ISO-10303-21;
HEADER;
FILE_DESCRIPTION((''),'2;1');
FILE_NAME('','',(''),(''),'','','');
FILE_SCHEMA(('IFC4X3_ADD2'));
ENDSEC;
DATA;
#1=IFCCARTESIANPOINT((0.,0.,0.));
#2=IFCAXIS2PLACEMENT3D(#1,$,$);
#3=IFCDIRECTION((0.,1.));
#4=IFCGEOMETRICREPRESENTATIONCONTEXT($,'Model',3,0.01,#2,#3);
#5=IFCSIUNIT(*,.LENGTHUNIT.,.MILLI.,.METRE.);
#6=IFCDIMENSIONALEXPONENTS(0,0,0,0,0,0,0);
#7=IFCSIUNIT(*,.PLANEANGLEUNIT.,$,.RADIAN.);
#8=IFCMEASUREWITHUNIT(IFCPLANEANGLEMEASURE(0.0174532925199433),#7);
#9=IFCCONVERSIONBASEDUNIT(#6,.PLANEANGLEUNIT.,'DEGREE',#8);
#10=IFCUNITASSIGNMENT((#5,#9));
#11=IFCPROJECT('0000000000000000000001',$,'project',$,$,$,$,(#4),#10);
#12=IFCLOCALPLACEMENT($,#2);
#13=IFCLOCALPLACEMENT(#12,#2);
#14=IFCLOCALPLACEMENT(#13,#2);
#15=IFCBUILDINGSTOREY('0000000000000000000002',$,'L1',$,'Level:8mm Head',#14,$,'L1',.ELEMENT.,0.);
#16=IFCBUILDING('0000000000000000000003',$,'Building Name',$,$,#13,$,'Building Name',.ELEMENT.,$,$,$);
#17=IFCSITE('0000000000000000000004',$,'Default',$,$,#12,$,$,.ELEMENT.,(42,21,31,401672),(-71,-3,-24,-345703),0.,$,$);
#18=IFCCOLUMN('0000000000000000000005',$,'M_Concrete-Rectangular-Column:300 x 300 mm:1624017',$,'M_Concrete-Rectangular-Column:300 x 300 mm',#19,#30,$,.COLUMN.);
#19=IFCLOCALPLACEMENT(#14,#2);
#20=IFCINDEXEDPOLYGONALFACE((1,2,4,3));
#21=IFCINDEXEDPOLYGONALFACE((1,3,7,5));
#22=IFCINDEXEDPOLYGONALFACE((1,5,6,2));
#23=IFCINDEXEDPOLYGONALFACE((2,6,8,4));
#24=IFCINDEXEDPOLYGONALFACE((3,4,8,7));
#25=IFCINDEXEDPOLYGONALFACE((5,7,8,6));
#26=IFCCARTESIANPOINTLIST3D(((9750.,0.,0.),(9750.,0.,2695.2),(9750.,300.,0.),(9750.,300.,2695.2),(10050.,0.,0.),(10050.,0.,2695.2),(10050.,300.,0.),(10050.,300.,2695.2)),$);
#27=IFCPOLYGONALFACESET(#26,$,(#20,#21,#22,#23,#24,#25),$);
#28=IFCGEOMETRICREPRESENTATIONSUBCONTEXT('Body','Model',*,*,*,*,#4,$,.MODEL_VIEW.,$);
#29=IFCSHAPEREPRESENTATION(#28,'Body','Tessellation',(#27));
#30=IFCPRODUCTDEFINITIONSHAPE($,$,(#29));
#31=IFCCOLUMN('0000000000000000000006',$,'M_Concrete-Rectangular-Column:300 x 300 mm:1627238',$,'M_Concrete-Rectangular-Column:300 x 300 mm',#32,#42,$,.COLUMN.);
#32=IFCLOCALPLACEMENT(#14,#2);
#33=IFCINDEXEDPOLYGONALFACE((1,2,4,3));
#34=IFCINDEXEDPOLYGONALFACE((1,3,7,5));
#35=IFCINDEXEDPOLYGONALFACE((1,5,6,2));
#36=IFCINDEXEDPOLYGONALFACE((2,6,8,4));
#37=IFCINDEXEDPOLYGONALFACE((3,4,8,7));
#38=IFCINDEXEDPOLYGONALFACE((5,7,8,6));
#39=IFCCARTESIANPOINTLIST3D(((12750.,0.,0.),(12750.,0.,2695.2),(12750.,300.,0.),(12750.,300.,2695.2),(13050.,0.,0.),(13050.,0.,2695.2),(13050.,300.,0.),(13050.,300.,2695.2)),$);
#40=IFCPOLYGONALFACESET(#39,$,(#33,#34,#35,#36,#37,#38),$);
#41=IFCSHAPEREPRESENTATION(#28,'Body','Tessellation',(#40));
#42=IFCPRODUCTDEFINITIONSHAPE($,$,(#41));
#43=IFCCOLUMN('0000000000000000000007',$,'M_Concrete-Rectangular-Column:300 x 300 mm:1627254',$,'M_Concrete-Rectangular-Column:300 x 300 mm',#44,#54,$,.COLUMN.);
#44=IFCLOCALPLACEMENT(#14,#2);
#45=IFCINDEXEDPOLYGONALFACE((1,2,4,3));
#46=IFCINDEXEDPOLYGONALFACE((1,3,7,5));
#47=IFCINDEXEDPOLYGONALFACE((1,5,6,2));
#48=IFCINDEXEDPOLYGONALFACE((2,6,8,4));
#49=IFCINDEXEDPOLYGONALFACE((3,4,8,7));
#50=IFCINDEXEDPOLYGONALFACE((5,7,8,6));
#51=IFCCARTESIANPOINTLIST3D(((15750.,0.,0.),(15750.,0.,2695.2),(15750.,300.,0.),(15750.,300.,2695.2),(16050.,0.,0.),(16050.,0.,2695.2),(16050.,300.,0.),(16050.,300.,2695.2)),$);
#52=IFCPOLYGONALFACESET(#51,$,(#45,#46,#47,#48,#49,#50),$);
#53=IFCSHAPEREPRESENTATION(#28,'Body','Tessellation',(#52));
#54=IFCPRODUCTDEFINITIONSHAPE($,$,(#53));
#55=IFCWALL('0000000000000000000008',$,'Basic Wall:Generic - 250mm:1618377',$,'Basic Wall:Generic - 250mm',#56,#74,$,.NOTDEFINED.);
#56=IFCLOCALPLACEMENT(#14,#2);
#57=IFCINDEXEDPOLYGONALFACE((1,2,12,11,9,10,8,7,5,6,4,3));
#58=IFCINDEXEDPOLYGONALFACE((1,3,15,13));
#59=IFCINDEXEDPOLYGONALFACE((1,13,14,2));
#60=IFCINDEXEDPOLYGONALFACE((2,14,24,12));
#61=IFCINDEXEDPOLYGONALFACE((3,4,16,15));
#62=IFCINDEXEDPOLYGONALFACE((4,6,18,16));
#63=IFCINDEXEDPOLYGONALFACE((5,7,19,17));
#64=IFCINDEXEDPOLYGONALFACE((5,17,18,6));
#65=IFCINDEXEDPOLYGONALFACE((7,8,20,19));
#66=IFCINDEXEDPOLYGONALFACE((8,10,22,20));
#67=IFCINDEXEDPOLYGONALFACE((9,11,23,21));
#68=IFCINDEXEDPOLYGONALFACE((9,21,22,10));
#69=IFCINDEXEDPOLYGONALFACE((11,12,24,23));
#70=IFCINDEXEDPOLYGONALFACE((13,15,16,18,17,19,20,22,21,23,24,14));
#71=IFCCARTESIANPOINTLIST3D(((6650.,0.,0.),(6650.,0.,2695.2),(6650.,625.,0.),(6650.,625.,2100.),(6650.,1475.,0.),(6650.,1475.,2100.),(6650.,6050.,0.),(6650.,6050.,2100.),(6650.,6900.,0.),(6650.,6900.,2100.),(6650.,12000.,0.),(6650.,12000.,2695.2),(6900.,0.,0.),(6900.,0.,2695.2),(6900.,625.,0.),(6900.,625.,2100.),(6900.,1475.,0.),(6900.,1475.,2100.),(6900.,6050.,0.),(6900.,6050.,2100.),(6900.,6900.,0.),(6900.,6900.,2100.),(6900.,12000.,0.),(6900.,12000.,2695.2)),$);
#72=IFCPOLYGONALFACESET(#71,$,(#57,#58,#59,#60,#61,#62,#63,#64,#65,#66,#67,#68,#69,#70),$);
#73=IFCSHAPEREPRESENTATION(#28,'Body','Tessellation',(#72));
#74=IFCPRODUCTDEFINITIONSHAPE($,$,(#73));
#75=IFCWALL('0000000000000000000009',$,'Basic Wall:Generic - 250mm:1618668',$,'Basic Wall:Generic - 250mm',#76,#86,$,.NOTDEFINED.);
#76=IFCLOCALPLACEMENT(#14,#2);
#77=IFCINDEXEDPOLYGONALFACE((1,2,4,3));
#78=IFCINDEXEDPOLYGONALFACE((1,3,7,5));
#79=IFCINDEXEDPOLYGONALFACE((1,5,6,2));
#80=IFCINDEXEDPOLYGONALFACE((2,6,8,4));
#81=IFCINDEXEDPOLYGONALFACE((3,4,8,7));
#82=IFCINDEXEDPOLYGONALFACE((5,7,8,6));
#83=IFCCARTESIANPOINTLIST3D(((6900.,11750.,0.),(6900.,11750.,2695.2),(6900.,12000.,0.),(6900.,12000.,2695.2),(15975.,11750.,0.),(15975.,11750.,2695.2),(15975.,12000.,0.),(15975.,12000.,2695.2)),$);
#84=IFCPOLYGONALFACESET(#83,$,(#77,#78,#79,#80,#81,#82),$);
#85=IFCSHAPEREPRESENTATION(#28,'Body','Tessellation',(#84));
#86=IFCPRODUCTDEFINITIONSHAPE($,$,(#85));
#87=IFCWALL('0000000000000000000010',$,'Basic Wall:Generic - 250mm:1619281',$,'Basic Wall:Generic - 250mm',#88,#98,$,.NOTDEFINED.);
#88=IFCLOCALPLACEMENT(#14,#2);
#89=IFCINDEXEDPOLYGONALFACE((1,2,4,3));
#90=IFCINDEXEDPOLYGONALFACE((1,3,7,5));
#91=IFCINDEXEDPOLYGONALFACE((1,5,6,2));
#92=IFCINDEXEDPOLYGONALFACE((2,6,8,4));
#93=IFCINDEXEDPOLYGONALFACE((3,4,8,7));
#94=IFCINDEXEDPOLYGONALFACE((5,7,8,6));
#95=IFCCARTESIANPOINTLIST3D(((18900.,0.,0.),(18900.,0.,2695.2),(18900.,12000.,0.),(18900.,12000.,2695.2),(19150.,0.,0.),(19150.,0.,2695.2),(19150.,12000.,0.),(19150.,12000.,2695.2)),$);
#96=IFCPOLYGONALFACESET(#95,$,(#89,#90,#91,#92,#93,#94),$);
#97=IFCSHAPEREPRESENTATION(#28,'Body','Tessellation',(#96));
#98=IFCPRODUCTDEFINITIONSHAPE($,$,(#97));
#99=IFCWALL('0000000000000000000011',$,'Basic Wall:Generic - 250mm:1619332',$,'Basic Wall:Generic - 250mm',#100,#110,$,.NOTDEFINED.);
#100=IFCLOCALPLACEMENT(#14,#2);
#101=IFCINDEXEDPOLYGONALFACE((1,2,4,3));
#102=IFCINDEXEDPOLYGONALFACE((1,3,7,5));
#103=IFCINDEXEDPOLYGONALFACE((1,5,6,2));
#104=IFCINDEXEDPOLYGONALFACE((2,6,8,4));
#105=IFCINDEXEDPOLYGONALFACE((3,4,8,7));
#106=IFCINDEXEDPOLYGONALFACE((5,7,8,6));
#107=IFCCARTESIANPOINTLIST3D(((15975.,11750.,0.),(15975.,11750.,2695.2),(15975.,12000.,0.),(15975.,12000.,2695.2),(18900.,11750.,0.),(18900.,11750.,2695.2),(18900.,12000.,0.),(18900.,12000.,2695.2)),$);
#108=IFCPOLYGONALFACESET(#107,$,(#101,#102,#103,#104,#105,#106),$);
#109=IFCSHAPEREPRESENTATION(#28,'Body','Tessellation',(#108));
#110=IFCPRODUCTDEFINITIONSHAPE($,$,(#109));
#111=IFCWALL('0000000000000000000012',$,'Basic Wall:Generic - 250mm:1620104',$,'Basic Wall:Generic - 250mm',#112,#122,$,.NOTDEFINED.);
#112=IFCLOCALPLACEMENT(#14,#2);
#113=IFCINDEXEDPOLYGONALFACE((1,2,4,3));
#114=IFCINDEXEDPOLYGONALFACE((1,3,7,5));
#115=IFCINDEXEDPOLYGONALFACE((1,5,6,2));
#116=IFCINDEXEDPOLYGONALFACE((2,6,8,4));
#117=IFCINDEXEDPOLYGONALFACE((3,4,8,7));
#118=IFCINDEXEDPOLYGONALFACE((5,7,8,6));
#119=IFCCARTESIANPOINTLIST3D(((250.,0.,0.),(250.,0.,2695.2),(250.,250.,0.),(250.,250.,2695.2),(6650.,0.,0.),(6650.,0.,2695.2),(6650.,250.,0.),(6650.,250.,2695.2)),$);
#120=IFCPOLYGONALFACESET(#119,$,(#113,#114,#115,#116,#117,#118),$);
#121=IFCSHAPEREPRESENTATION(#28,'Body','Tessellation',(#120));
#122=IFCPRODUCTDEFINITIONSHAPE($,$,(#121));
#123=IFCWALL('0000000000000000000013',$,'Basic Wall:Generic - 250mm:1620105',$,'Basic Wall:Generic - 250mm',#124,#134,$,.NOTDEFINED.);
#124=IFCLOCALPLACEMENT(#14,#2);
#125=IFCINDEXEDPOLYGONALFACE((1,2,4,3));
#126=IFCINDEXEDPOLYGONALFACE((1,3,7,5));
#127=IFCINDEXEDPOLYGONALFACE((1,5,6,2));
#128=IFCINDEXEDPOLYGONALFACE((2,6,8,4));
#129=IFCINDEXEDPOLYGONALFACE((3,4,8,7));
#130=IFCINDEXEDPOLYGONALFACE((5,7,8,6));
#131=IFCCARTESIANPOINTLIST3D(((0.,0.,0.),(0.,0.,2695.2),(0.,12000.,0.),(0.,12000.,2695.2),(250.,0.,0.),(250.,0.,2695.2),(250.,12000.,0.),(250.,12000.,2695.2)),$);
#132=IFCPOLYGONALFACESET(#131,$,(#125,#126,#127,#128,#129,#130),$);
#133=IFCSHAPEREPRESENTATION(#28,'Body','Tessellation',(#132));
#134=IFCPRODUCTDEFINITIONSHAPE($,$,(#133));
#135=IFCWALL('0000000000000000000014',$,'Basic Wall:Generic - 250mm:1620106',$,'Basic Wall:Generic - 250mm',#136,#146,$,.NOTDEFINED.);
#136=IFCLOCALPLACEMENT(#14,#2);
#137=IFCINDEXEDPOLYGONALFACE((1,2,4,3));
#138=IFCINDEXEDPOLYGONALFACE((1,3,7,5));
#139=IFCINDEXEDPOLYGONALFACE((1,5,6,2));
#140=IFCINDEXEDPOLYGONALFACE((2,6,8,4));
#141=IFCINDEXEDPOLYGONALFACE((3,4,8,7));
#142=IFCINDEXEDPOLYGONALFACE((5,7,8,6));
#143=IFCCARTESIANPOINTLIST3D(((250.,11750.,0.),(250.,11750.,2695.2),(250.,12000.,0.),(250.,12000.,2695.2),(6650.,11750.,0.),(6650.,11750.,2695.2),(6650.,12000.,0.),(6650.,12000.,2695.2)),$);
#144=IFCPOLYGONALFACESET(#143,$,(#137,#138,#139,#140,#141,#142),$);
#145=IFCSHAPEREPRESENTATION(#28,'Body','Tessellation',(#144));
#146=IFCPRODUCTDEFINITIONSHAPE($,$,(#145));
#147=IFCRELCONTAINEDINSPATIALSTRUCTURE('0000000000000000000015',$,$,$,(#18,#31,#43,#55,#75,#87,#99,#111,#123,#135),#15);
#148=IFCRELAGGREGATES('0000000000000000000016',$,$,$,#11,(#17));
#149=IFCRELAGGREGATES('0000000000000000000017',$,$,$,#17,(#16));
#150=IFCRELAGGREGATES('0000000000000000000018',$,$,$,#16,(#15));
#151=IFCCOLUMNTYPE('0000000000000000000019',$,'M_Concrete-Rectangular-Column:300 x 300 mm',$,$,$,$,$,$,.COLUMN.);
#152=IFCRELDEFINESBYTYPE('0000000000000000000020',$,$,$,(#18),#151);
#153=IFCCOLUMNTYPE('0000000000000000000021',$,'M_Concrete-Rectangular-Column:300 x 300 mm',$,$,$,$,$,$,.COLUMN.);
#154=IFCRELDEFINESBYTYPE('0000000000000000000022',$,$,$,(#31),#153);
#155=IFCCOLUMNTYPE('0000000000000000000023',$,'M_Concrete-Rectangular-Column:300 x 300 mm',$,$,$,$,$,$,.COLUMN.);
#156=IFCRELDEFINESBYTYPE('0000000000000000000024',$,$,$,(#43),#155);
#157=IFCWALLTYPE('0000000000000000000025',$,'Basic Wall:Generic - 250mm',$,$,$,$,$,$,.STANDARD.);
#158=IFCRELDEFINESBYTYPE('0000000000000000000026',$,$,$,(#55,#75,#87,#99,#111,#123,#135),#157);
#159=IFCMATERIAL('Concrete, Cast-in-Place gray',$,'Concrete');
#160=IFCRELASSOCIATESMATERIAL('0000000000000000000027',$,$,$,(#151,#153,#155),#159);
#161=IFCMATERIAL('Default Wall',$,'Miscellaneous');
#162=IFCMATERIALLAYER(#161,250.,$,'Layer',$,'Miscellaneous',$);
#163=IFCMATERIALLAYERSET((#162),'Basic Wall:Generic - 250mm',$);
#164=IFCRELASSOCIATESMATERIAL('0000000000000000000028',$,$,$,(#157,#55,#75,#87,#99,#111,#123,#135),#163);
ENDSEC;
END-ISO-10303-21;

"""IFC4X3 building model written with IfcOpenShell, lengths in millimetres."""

from ifc_helpers import new_model, entity, si_unit, converted_unit, direction, frame, frame_2d, origin, place, context, subcontext, project, spatial, polyline, rectangle, extrude, clip, bounded_halfspace, source, transform, mapped, material, layer, layer_set, material_profile, profile_set, type_object, type_shapes, element, save


model = new_model("IFC4X3")

# Units and contexts
model_context = context("Model", 3, precision=0.01, world=origin(), true_north=direction((0.0, 1.0)))
body_context = subcontext(model_context, "Body", "Model", "MODEL_VIEW")
ifc_project = project(units=[si_unit("LENGTHUNIT", "METRE", prefix="MILLI"), converted_unit("PLANEANGLEUNIT", "DEGREE", entity("IfcPlaneAngleMeasure", 0.0174532925199433), si_unit("PLANEANGLEUNIT", "RADIAN"), dimensions=[0, 0, 0, 0, 0, 0, 0])], contexts=[model_context])

# Site, building, storey
site_placement = place(None, origin())
site = spatial("IfcSite", under=ifc_project, at=site_placement, Name="Default", CompositionType="ELEMENT", RefLatitude=(42, 21, 31, 401672), RefLongitude=(-71, -3, -24, -345703), RefElevation=0.0)
building_placement = place(site_placement, origin())
building = spatial("IfcBuilding", under=site, at=building_placement, Name="Building Name", LongName="Building Name", CompositionType="ELEMENT")
storey_placement = place(building_placement, origin())
storey = spatial("IfcBuildingStorey", under=building, at=storey_placement, Name="L1", ObjectType="Level:8mm Head", LongName="L1", CompositionType="ELEMENT", Elevation=0.0)

# Columns
ifc_material_1 = material(Name="Concrete, Cast-in-Place gray", Category="Concrete")
ifc_material_profile = material_profile(ifc_material_1, rectangle(XDim=300.0, YDim=300.0, at=frame_2d((0.0, 0.0), x_axis=(1.0, 0.0))), Name="300 x 300 mm")
ifc_profile_set = profile_set([ifc_material_profile], Name="300 x 300 mm")
column_type_1 = type_object("IfcColumnType", Name="M_Concrete-Rectangular-Column:300 x 300 mm", PredefinedType="COLUMN", material=ifc_profile_set)
shared_shape_1 = source(origin(), body_context, "Body", "SweptSolid", [
    extrude(rectangle(XDim=300.0, YDim=300.0, at=frame_2d((0.0, 0.0), x_axis=(1.0, 0.0))), frame((9900.0, 150.0, 0.0), z_axis=(0.0, 0.0, 1.0), x_axis=(-1.0, 0.0, 0.0)), (0.0, 0.0, 1.0), 2695.2),
])
type_shapes(column_type_1, [shared_shape_1])
column_1_placement = place(storey_placement, origin())
element("IfcColumn", 1, at=column_1_placement, inside=storey, type_object=column_type_1, Name="M_Concrete-Rectangular-Column:300 x 300 mm:1624017", ObjectType="M_Concrete-Rectangular-Column:300 x 300 mm", PredefinedType="COLUMN", context=body_context, shape_type="MappedRepresentation", body=[
    mapped(shared_shape_1, transform((0.0, 0.0, 0.0), scale=1.0)),
])
column_type_2 = type_object("IfcColumnType", Name="M_Concrete-Rectangular-Column:300 x 300 mm", PredefinedType="COLUMN", material=ifc_profile_set)
shared_shape_2 = source(origin(), body_context, "Body", "SweptSolid", [
    extrude(rectangle(XDim=300.0, YDim=300.0, at=frame_2d((0.0, 0.0), x_axis=(1.0, 0.0))), frame((12900.0, 150.0, 0.0), z_axis=(0.0, 0.0, 1.0), x_axis=(-1.0, 0.0, 0.0)), (0.0, 0.0, 1.0), 2695.2),
])
type_shapes(column_type_2, [shared_shape_2])
column_2_placement = place(storey_placement, origin())
element("IfcColumn", 2, at=column_2_placement, inside=storey, type_object=column_type_2, Name="M_Concrete-Rectangular-Column:300 x 300 mm:1627238", ObjectType="M_Concrete-Rectangular-Column:300 x 300 mm", PredefinedType="COLUMN", context=body_context, shape_type="MappedRepresentation", body=[
    mapped(shared_shape_2, transform((0.0, 0.0, 0.0), scale=1.0)),
])
column_type_3 = type_object("IfcColumnType", Name="M_Concrete-Rectangular-Column:300 x 300 mm", PredefinedType="COLUMN", material=ifc_profile_set)
shared_shape_3 = source(origin(), body_context, "Body", "SweptSolid", [
    extrude(rectangle(XDim=300.0, YDim=300.0, at=frame_2d((0.0, 0.0), x_axis=(1.0, 0.0))), frame((15900.0, 150.0, 0.0), z_axis=(0.0, 0.0, 1.0), x_axis=(-1.0, 0.0, 0.0)), (0.0, 0.0, 1.0), 2695.2),
])
type_shapes(column_type_3, [shared_shape_3])
column_3_placement = place(storey_placement, origin())
element("IfcColumn", 3, at=column_3_placement, inside=storey, type_object=column_type_3, Name="M_Concrete-Rectangular-Column:300 x 300 mm:1627254", ObjectType="M_Concrete-Rectangular-Column:300 x 300 mm", PredefinedType="COLUMN", context=body_context, shape_type="MappedRepresentation", body=[
    mapped(shared_shape_3, transform((0.0, 0.0, 0.0), scale=1.0)),
])

# Wall, openings
ifc_material_2 = material(Name="Default Wall", Category="Miscellaneous")
ifc_layer = layer(ifc_material_2, 250.0, Name="Layer", Category="Miscellaneous")
ifc_layer_set = layer_set([ifc_layer], Name="Basic Wall:Generic - 250mm")
wall_type = type_object("IfcWallType", Name="Basic Wall:Generic - 250mm", PredefinedType="STANDARD", material=ifc_layer_set)
wall_1_placement = place(storey_placement, frame((6775.0, 12000.0, 0.0), z_axis=(0.0, 0.0, 1.0), x_axis=(0.0, -1.0, 0.0)))
wall_1 = element("IfcWall", 4, at=wall_1_placement, inside=storey, type_object=wall_type, material=ifc_layer_set, Name="Basic Wall:Generic - 250mm:1618377", ObjectType="Basic Wall:Generic - 250mm", PredefinedType="NOTDEFINED", context=body_context, shape_type="Clipping", body=[
    clip(extrude(rectangle(XDim=12000.0, YDim=250.0, at=frame_2d((6000.0, 0.0), x_axis=(1.0, 0.0))), origin(), (0.0, 0.0, 1.0), 2695.2), bounded_halfspace(frame((0.0, -125.0, 2695.2), z_axis=(0.0, 0.0, -1.0), x_axis=(0.0, -1.0, 0.0)), True, frame((0.0, -125.0, 2695.2)), polyline([(0.0, 0.0), (250.0, 0.0), (11750.0, 0.0), (12000.0, 0.0), (12000.0, 250.0), (250.0, 250.0), (0.0, 250.0), (0.0, 0.0)]))),
])
opening_1_placement = place(wall_1_placement, frame((10525.0, -125.0, 0.0)))
element("IfcOpeningElement", 5, at=opening_1_placement, cuts=wall_1, PredefinedType="OPENING", context=body_context, shape_type="SweptSolid", body=[
    extrude(rectangle(XDim=2100.0, YDim=850.0, at=frame_2d((1050.0, 425.0), x_axis=(1.0, 0.0))), frame((0.0, 0.0, 0.0), z_axis=(0.0, 1.0, 0.0), x_axis=(0.0, 0.0, 1.0)), (0.0, 0.0, 1.0), 250.0),
])
opening_2_placement = place(wall_1_placement, frame((5100.0, -125.0, 0.0)))
element("IfcOpeningElement", 6, at=opening_2_placement, cuts=wall_1, PredefinedType="OPENING", context=body_context, shape_type="SweptSolid", body=[
    extrude(rectangle(XDim=2100.0, YDim=850.0, at=frame_2d((1050.0, 425.0), x_axis=(1.0, 0.0))), frame((0.0, 0.0, 0.0), z_axis=(0.0, 1.0, 0.0), x_axis=(0.0, 0.0, 1.0)), (0.0, 0.0, 1.0), 250.0),
])

# Walls
wall_2_placement = place(storey_placement, frame((15975.0, 11875.0, 0.0), z_axis=(0.0, 0.0, 1.0), x_axis=(-1.0, 0.0, 0.0)))
element("IfcWall", 7, at=wall_2_placement, inside=storey, type_object=wall_type, material=ifc_layer_set, Name="Basic Wall:Generic - 250mm:1618668", ObjectType="Basic Wall:Generic - 250mm", PredefinedType="NOTDEFINED", context=body_context, shape_type="Clipping", body=[
    clip(extrude(rectangle(XDim=9075.0, YDim=250.0, at=frame_2d((4537.5, 0.0), x_axis=(-1.0, 0.0))), origin(), (0.0, 0.0, 1.0), 2695.2), bounded_halfspace(frame((0.0, -125.0, 2695.2), z_axis=(0.0, 0.0, -1.0), x_axis=(1.0, 0.0, 0.0)), True, frame((0.0, -125.0, 2695.2)), polyline([(0.0, 0.0), (9075.0, 0.0), (9075.0, 250.0), (0.0, 250.0), (0.0, 0.0)]))),
])
wall_3_placement = place(storey_placement, frame((19025.0, 0.0, 0.0), z_axis=(0.0, 0.0, 1.0), x_axis=(0.0, 1.0, 0.0)))
element("IfcWall", 8, at=wall_3_placement, inside=storey, type_object=wall_type, material=ifc_layer_set, Name="Basic Wall:Generic - 250mm:1619281", ObjectType="Basic Wall:Generic - 250mm", PredefinedType="NOTDEFINED", context=body_context, shape_type="Clipping", body=[
    clip(extrude(rectangle(XDim=12000.0, YDim=250.0, at=frame_2d((6000.0, 0.0), x_axis=(-1.0, 0.0))), origin(), (0.0, 0.0, 1.0), 2695.2), bounded_halfspace(frame((0.0, -125.0, 2695.2), z_axis=(0.0, 0.0, -1.0), x_axis=(0.0, 1.0, 0.0)), True, frame((0.0, -125.0, 2695.2)), polyline([(0.0, 0.0), (12000.0, 0.0), (12000.0, 250.0), (11750.0, 250.0), (0.0, 250.0), (0.0, 0.0)]))),
])
wall_4_placement = place(storey_placement, frame((18900.0, 11875.0, 0.0), z_axis=(0.0, 0.0, 1.0), x_axis=(-1.0, 0.0, 0.0)))
element("IfcWall", 9, at=wall_4_placement, inside=storey, type_object=wall_type, material=ifc_layer_set, Name="Basic Wall:Generic - 250mm:1619332", ObjectType="Basic Wall:Generic - 250mm", PredefinedType="NOTDEFINED", context=body_context, shape_type="Clipping", body=[
    clip(extrude(rectangle(XDim=2925.0, YDim=250.0, at=frame_2d((1462.5, 0.0), x_axis=(-1.0, 0.0))), origin(), (0.0, 0.0, 1.0), 2695.2), bounded_halfspace(frame((0.0, -125.0, 2695.2), z_axis=(0.0, 0.0, -1.0), x_axis=(1.0, 0.0, 0.0)), True, frame((0.0, -125.0, 2695.2)), polyline([(0.0, 0.0), (2925.0, 0.0), (2925.0, 250.0), (0.0, 250.0), (0.0, 0.0)]))),
])
wall_5_placement = place(storey_placement, frame((6650.0, 125.0, 0.0), z_axis=(0.0, 0.0, 1.0), x_axis=(-1.0, 0.0, 0.0)))
element("IfcWall", 10, at=wall_5_placement, inside=storey, type_object=wall_type, material=ifc_layer_set, Name="Basic Wall:Generic - 250mm:1620104", ObjectType="Basic Wall:Generic - 250mm", PredefinedType="NOTDEFINED", context=body_context, shape_type="Clipping", body=[
    clip(extrude(rectangle(XDim=6400.0, YDim=250.0, at=frame_2d((3200.0, 0.0), x_axis=(-1.0, 0.0))), origin(), (0.0, 0.0, 1.0), 2695.2), bounded_halfspace(frame((0.0, -125.0, 2695.2), z_axis=(0.0, 0.0, -1.0), x_axis=(1.0, 0.0, 0.0)), True, frame((0.0, -125.0, 2695.2)), polyline([(0.0, 0.0), (6400.0, 0.0), (6400.0, 250.0), (0.0, 250.0), (0.0, 0.0)]))),
])
wall_6_placement = place(storey_placement, frame((125.0, 0.0, 0.0), z_axis=(0.0, 0.0, 1.0), x_axis=(0.0, 1.0, 0.0)))
element("IfcWall", 11, at=wall_6_placement, inside=storey, type_object=wall_type, material=ifc_layer_set, Name="Basic Wall:Generic - 250mm:1620105", ObjectType="Basic Wall:Generic - 250mm", PredefinedType="NOTDEFINED", context=body_context, shape_type="Clipping", body=[
    clip(extrude(rectangle(XDim=12000.0, YDim=250.0, at=frame_2d((6000.0, 0.0), x_axis=(-1.0, 0.0))), origin(), (0.0, 0.0, 1.0), 2695.2), bounded_halfspace(frame((0.0, -125.0, 2695.2), z_axis=(0.0, 0.0, -1.0), x_axis=(0.0, 1.0, 0.0)), True, frame((0.0, -125.0, 2695.2)), polyline([(0.0, 0.0), (250.0, 0.0), (11750.0, 0.0), (12000.0, 0.0), (12000.0, 250.0), (0.0, 250.0), (0.0, 0.0)]))),
])
wall_7_placement = place(storey_placement, frame((250.0, 11875.0, 0.0)))
element("IfcWall", 12, at=wall_7_placement, inside=storey, type_object=wall_type, material=ifc_layer_set, Name="Basic Wall:Generic - 250mm:1620106", ObjectType="Basic Wall:Generic - 250mm", PredefinedType="NOTDEFINED", context=body_context, shape_type="Clipping", body=[
    clip(extrude(rectangle(XDim=6400.0, YDim=250.0, at=frame_2d((3200.0, 0.0), x_axis=(-1.0, 0.0))), origin(), (0.0, 0.0, 1.0), 2695.2), bounded_halfspace(frame((0.0, -125.0, 2695.2), z_axis=(0.0, 0.0, -1.0), x_axis=(-1.0, 0.0, 0.0)), True, frame((0.0, -125.0, 2695.2)), polyline([(0.0, 0.0), (6400.0, 0.0), (6400.0, 250.0), (0.0, 250.0), (0.0, 0.0)]))),
])

save(model, "model.ifc")
